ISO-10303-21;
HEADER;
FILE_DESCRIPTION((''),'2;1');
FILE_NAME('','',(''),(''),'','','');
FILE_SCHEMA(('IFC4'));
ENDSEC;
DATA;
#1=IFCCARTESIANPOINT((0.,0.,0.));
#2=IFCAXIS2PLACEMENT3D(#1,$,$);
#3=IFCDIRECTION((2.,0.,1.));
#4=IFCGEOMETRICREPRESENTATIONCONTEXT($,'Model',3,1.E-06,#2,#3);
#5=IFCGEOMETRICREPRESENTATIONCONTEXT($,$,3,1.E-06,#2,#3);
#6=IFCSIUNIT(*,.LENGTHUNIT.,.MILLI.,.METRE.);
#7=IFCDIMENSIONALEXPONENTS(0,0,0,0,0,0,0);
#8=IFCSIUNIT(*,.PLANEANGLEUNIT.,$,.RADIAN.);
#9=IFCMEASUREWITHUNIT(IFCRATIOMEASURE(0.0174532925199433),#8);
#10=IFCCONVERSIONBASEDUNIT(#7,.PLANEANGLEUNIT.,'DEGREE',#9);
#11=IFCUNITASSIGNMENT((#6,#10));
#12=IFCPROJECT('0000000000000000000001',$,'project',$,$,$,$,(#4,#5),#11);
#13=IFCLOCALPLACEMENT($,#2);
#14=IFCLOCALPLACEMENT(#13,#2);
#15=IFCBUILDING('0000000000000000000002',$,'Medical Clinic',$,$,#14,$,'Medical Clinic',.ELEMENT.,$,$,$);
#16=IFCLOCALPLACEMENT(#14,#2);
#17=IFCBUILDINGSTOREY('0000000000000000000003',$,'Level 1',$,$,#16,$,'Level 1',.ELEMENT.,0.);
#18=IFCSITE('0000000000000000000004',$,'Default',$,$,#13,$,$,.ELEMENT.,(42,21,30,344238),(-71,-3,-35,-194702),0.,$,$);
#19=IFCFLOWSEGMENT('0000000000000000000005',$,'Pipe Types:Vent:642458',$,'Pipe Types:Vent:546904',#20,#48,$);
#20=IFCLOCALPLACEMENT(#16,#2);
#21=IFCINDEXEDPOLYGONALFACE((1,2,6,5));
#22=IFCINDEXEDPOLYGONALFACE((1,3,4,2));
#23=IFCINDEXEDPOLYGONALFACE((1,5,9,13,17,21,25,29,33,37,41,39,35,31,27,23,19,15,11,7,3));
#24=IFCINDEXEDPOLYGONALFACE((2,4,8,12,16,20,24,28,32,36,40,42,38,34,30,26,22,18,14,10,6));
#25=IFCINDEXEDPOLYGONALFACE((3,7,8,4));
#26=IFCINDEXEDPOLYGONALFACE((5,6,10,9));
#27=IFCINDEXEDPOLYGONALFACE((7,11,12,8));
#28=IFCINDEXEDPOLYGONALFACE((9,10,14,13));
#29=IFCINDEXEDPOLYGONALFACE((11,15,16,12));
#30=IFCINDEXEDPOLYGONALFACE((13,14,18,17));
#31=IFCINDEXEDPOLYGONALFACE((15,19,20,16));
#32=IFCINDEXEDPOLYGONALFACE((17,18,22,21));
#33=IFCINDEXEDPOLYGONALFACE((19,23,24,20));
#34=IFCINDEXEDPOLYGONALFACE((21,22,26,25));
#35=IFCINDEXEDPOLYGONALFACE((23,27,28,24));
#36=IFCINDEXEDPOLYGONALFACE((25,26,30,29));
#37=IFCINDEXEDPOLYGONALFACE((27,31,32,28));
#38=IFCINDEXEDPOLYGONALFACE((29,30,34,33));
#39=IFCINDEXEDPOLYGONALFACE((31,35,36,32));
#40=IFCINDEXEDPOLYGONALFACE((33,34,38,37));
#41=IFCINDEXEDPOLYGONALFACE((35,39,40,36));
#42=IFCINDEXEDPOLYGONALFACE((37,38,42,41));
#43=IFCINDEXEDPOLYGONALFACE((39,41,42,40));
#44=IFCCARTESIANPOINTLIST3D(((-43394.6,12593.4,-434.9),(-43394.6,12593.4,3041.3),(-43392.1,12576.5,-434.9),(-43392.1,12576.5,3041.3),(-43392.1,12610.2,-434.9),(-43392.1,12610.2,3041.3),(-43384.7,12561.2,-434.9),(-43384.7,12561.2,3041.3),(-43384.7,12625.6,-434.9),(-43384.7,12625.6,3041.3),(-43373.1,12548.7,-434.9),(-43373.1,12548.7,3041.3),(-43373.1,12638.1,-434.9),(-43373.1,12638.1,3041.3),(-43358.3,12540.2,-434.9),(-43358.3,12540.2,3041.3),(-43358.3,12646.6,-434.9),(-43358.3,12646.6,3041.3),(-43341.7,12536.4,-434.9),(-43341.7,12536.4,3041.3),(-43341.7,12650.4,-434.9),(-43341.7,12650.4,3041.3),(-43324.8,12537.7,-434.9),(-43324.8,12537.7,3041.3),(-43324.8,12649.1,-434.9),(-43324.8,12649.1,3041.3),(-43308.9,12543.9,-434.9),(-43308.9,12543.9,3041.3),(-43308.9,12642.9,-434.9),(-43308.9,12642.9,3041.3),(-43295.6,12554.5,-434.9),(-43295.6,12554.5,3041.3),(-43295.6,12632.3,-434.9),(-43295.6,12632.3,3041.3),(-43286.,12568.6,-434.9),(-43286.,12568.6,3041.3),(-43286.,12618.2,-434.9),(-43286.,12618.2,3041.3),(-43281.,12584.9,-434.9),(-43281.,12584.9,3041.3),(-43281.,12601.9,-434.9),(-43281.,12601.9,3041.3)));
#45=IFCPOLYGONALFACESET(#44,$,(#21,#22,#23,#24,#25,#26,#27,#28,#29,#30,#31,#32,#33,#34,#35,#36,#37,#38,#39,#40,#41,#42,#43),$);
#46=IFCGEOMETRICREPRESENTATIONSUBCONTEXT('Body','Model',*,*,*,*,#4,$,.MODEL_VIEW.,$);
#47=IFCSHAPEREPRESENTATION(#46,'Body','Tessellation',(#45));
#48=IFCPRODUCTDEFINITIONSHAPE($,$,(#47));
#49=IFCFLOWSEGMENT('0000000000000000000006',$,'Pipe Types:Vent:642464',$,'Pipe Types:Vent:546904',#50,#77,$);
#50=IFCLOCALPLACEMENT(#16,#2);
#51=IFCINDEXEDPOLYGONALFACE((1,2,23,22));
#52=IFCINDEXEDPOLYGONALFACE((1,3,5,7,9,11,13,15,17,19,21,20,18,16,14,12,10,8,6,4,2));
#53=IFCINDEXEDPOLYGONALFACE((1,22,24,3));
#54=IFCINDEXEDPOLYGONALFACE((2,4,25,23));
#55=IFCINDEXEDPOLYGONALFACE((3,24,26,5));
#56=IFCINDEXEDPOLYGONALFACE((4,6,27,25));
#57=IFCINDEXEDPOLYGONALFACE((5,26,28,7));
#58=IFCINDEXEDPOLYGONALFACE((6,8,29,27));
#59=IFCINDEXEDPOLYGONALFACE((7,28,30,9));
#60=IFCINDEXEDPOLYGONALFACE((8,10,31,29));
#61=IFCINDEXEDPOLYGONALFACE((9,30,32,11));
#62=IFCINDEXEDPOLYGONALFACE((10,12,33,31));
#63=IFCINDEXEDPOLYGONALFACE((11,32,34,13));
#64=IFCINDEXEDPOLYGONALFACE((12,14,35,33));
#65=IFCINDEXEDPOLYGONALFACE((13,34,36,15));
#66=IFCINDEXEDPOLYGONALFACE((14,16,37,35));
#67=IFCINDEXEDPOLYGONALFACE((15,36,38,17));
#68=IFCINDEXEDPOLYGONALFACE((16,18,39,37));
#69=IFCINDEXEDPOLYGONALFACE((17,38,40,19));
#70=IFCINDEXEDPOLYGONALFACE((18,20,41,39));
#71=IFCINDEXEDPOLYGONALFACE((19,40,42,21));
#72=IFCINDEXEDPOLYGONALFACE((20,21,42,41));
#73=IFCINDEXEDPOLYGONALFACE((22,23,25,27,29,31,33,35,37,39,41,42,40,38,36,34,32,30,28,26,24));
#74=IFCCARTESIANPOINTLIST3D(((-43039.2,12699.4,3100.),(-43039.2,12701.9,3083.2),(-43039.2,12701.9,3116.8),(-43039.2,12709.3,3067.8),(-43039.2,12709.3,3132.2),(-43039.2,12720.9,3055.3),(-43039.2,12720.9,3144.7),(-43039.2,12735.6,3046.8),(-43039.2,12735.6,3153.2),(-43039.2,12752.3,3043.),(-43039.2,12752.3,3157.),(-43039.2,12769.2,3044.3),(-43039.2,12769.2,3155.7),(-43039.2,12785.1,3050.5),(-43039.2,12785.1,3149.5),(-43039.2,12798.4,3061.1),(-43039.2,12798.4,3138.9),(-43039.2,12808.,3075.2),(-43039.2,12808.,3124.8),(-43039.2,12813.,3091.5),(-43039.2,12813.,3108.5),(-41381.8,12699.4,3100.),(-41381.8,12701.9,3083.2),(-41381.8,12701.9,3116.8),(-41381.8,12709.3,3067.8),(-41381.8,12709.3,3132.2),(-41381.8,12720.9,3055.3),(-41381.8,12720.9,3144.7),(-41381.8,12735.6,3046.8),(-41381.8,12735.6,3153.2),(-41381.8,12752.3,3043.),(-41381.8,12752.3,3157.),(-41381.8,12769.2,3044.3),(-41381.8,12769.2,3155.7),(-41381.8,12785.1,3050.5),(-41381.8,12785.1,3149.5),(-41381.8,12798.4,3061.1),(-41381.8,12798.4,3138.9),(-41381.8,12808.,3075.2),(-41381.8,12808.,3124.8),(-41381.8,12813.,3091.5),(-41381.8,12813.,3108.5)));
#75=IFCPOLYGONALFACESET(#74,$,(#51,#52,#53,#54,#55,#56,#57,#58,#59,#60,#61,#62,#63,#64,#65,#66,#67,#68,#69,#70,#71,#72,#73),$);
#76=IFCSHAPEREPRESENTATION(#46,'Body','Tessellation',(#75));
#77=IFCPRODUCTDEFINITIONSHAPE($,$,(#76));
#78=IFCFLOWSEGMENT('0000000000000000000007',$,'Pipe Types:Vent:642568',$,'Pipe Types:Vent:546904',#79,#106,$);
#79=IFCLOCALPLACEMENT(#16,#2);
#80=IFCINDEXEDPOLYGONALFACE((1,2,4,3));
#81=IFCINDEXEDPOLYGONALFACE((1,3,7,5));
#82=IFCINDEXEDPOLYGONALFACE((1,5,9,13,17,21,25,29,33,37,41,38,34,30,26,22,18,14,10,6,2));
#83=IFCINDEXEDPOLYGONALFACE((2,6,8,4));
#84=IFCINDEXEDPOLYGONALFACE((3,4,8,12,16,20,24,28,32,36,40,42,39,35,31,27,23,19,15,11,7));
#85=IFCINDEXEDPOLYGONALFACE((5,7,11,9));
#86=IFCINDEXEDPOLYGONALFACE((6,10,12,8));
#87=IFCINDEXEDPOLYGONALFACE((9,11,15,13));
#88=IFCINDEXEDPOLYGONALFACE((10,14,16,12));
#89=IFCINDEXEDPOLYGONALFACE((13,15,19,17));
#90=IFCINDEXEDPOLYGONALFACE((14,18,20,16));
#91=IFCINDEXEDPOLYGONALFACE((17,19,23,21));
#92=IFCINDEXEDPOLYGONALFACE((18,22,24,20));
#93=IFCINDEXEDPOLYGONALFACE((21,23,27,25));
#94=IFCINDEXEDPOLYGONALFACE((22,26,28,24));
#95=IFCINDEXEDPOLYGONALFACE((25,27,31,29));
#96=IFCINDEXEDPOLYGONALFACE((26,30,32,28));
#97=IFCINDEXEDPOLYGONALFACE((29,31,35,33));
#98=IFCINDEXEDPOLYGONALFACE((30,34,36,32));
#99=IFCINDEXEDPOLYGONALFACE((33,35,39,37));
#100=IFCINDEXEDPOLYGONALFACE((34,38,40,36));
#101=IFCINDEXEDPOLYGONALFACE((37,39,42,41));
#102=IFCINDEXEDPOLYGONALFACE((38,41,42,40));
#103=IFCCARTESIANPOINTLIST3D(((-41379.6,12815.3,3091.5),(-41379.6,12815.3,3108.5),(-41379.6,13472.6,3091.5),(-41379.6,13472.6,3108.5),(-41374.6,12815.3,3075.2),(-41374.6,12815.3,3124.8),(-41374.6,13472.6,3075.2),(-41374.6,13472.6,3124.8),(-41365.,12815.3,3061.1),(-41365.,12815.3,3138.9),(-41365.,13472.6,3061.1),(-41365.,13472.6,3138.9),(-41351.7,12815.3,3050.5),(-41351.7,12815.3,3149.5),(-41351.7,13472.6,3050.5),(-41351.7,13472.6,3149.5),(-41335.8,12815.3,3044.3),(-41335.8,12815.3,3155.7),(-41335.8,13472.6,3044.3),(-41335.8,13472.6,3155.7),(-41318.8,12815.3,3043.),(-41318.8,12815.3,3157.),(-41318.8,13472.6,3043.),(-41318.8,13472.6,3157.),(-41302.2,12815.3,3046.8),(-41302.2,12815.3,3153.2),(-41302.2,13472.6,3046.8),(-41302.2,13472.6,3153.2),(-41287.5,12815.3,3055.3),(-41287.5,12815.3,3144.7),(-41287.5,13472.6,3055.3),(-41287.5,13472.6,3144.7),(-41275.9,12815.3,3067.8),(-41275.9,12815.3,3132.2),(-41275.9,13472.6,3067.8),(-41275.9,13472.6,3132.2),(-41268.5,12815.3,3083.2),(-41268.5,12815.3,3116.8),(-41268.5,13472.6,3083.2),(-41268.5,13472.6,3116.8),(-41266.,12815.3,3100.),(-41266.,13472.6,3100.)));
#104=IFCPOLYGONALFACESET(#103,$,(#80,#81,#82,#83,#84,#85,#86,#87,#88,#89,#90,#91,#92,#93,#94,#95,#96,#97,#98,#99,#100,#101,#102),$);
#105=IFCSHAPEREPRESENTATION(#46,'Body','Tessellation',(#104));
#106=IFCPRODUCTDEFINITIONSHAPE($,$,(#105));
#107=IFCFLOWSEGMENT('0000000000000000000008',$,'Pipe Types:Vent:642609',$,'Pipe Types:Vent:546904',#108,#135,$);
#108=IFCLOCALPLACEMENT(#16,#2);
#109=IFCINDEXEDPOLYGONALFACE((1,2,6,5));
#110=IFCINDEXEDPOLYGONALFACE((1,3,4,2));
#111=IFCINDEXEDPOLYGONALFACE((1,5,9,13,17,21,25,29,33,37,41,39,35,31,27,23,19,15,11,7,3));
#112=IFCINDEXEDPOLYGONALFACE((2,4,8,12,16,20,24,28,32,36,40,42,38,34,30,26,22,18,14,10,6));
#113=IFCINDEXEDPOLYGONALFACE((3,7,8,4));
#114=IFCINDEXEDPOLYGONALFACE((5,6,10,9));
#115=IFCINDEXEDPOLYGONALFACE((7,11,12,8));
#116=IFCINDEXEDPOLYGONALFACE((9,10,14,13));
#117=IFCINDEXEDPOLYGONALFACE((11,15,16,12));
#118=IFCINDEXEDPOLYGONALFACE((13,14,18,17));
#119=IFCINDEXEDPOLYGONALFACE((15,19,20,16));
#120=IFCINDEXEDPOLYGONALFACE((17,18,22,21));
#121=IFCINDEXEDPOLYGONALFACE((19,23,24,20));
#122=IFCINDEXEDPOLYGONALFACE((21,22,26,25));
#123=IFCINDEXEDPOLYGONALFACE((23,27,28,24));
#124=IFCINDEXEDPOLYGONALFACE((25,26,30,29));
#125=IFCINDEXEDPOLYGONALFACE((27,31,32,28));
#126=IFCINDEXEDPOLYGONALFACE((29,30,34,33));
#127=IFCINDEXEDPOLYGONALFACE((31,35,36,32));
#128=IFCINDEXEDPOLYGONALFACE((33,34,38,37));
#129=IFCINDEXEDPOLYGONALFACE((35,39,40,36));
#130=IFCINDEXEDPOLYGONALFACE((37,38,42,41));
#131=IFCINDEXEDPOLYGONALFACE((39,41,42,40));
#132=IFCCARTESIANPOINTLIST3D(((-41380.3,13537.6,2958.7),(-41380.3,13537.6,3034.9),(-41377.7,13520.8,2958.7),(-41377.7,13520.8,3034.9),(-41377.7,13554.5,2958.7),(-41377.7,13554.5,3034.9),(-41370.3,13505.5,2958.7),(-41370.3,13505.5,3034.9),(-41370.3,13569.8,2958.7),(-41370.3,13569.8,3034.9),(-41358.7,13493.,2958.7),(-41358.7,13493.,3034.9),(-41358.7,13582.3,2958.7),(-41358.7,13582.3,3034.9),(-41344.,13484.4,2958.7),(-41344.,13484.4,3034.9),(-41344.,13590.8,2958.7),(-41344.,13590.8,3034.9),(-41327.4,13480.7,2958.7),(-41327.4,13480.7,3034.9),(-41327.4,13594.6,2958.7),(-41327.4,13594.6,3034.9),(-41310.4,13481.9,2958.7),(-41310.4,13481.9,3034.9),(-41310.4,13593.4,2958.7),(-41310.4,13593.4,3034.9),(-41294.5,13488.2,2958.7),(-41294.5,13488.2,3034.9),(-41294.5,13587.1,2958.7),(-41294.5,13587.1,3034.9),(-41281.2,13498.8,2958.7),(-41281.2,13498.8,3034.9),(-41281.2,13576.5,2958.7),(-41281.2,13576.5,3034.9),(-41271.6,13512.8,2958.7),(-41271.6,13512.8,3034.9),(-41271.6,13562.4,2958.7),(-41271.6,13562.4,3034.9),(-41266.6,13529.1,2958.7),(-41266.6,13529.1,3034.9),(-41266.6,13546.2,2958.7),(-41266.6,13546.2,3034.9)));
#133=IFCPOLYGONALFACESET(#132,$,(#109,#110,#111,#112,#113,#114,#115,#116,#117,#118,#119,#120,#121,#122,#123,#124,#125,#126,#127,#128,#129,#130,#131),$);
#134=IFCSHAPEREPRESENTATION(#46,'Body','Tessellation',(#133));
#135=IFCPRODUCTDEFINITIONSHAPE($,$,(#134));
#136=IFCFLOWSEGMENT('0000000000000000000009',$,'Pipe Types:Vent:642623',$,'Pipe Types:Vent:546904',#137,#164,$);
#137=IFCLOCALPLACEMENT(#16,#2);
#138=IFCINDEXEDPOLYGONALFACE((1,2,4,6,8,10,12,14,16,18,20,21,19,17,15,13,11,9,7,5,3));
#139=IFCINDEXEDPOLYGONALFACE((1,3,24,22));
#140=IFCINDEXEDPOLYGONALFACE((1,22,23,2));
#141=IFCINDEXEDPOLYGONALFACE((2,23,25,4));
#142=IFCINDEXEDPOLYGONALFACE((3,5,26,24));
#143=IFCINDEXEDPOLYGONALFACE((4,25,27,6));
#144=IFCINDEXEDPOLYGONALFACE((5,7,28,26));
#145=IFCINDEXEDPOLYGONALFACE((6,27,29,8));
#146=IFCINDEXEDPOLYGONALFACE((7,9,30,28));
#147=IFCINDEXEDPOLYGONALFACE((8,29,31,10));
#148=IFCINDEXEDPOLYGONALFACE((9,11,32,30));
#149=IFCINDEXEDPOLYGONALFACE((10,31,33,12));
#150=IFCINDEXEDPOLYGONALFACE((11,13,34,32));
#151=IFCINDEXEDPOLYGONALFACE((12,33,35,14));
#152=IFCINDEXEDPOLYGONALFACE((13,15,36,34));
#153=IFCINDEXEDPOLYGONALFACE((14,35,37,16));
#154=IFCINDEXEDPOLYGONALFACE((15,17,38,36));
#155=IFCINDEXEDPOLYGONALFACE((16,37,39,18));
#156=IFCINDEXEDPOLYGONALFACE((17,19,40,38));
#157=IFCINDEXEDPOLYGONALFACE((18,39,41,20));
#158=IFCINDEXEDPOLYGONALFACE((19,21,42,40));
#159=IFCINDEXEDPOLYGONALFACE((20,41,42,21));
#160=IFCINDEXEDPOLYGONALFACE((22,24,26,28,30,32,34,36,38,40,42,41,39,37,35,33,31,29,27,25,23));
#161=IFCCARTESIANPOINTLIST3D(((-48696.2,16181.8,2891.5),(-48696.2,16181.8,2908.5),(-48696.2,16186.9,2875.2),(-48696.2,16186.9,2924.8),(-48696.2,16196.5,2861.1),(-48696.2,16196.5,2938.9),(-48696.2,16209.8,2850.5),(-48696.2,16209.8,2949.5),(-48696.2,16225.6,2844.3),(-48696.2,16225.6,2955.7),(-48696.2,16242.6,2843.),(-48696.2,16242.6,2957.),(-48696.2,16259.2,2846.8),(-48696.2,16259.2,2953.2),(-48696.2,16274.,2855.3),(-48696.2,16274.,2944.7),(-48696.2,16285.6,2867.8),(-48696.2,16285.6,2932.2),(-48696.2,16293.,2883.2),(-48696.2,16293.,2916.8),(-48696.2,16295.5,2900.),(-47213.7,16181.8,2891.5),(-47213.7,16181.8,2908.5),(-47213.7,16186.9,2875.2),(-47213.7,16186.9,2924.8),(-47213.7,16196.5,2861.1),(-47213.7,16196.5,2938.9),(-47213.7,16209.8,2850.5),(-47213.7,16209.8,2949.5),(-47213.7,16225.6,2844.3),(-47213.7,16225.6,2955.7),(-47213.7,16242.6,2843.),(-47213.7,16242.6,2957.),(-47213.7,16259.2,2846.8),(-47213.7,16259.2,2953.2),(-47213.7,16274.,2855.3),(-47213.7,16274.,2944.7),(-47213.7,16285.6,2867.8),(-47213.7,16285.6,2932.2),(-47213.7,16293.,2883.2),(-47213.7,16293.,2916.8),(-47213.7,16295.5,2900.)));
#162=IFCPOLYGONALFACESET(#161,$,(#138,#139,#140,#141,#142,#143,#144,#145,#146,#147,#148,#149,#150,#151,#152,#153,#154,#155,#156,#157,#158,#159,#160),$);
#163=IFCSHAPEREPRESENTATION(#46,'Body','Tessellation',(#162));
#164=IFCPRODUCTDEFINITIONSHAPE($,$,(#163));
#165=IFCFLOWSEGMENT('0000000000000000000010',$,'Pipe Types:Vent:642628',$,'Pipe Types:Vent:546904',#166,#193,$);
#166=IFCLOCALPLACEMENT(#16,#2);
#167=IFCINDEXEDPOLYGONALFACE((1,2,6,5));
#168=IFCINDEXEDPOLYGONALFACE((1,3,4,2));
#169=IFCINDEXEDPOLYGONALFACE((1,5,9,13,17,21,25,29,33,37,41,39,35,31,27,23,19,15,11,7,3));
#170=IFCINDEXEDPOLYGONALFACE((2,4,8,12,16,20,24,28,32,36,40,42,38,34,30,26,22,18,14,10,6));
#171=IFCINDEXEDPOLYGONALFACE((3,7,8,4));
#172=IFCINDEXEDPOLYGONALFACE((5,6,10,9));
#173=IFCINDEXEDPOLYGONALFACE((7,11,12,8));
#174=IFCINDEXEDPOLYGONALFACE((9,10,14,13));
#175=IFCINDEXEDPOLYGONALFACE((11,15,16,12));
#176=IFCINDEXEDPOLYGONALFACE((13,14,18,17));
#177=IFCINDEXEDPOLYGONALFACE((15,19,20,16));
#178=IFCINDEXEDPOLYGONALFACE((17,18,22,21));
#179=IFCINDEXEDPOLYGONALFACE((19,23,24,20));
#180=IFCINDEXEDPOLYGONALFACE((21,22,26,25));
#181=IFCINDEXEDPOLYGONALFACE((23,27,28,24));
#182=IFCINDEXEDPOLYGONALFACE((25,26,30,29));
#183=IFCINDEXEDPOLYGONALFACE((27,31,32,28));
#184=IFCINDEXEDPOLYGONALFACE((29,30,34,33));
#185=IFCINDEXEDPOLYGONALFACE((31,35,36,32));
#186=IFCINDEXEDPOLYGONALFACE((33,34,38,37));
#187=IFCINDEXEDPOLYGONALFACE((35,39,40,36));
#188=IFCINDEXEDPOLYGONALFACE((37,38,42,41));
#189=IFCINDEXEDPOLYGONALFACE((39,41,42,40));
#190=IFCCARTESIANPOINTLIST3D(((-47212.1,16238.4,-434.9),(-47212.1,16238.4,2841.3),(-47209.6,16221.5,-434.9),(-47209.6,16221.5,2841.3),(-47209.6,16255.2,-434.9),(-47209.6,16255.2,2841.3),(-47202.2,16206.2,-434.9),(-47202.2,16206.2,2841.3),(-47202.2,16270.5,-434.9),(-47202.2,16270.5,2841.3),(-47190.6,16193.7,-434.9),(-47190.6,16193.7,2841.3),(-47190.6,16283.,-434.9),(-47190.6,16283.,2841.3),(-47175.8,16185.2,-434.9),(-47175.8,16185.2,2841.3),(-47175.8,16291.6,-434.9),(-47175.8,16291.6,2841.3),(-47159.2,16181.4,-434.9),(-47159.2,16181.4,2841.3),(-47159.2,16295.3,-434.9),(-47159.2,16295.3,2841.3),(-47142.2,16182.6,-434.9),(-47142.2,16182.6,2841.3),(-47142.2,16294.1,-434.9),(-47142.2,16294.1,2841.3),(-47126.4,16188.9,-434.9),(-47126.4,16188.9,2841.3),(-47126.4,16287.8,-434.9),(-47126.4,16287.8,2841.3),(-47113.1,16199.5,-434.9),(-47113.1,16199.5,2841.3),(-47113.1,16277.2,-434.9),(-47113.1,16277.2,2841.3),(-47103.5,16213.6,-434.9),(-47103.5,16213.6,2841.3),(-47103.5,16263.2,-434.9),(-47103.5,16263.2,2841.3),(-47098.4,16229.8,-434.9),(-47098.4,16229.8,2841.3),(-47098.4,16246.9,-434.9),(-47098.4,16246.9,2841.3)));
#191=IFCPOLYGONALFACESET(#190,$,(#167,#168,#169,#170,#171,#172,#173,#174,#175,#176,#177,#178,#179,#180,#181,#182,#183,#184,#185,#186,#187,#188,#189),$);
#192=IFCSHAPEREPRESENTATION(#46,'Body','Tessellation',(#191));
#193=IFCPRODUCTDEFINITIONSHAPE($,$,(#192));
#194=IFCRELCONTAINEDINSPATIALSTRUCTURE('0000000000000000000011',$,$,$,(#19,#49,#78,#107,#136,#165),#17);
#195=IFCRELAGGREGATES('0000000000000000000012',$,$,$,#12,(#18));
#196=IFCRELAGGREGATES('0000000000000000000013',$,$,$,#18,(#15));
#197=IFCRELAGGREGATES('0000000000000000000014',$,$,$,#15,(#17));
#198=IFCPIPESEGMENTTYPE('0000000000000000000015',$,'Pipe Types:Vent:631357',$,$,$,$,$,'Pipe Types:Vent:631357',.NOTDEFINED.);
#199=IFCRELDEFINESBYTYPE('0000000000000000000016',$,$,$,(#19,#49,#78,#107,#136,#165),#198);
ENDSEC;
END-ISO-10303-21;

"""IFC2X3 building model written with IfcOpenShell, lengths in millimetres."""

from ifc_helpers import new_model, entity, si_unit, converted_unit, direction, frame, origin, origin_2d_with_axis, place, context, subcontext, project, spatial, circle, extrude, type_object, element, save


model = new_model("IFC2X3")

# Units and contexts
model_context = context("Model", 3, precision=1e-06, world=origin(), true_north=direction((2.0, 0.0, 1.0)))
context_of_model = context(None, 3, precision=1e-06, world=origin(), true_north=direction((2.0, 0.0, 1.0)))
body_context = subcontext(model_context, "Body", "Model", "MODEL_VIEW")
ifc_project = project(units=[si_unit("LENGTHUNIT", "METRE", prefix="MILLI"), converted_unit("PLANEANGLEUNIT", "DEGREE", entity("IfcRatioMeasure", 0.0174532925199433), si_unit("PLANEANGLEUNIT", "RADIAN"), dimensions=[0, 0, 0, 0, 0, 0, 0])], contexts=[model_context, context_of_model])

# Site, building, storey
site_placement = place(None, origin())
site = spatial("IfcSite", under=ifc_project, at=site_placement, Name="Default", CompositionType="ELEMENT", RefLatitude=(42, 21, 30, 344238), RefLongitude=(-71, -3, -35, -194702), RefElevation=0.0)
building_placement = place(site_placement, origin())
building = spatial("IfcBuilding", under=site, at=building_placement, Name="Medical Clinic", LongName="Medical Clinic", CompositionType="ELEMENT")
storey_placement = place(building_placement, origin())
storey = spatial("IfcBuildingStorey", under=building, at=storey_placement, Name="Level 1", LongName="Level 1", CompositionType="ELEMENT", Elevation=0.0)

# Flow segments
pipe_segment_type_1 = type_object("IfcPipeSegmentType", Name="Pipe Types:Vent:631357", ElementType="Pipe Types:Vent:631357", PredefinedType="NOTDEFINED")
flow_segment_1_placement = place(storey_placement, origin())
element("IfcFlowSegment", 1, at=flow_segment_1_placement, inside=storey, type_object=pipe_segment_type_1, Name="Pipe Types:Vent:642458", ObjectType="Pipe Types:Vent:546904", context=body_context, shape_type="SweptSolid", body=[
    extrude(circle(Radius=57.1, at=origin_2d_with_axis()), frame((-43337.5, 12593.4, -434.9), z_axis=(0.0, 0.0, 1.0), x_axis=(-1.0, 0.0, 0.0)), (0.0, 0.0, 1.0), 3476.2),
])
flow_segment_2_placement = place(storey_placement, origin())
element("IfcFlowSegment", 2, at=flow_segment_2_placement, inside=storey, type_object=pipe_segment_type_1, Name="Pipe Types:Vent:642464", ObjectType="Pipe Types:Vent:546904", context=body_context, shape_type="SweptSolid", body=[
    extrude(circle(Radius=57.1, at=origin_2d_with_axis()), frame((-43039.2, 12756.5, 3100.0), z_axis=(1.0, 0.0, 0.0), x_axis=(0.0, -1.0, 0.0)), (0.0, 0.0, 1.0), 1657.3),
])
flow_segment_3_placement = place(storey_placement, origin())
element("IfcFlowSegment", 3, at=flow_segment_3_placement, inside=storey, type_object=pipe_segment_type_1, Name="Pipe Types:Vent:642568", ObjectType="Pipe Types:Vent:546904", context=body_context, shape_type="SweptSolid", body=[
    extrude(circle(Radius=57.1, at=origin_2d_with_axis()), frame((-41323.1, 12815.3, 3100.0), z_axis=(0.0, 1.0, 0.0), x_axis=(1.0, 0.0, 0.0)), (0.0, 0.0, 1.0), 657.3),
])
flow_segment_4_placement = place(storey_placement, origin())
element("IfcFlowSegment", 4, at=flow_segment_4_placement, inside=storey, type_object=pipe_segment_type_1, Name="Pipe Types:Vent:642609", ObjectType="Pipe Types:Vent:546904", context=body_context, shape_type="SweptSolid", body=[
    extrude(circle(Radius=57.1, at=origin_2d_with_axis()), frame((-41323.1, 13537.6, 2958.7), z_axis=(0.0, 0.0, 1.0), x_axis=(-1.0, 0.0, 0.0)), (0.0, 0.0, 1.0), 76.2),
])
flow_segment_5_placement = place(storey_placement, origin())
element("IfcFlowSegment", 5, at=flow_segment_5_placement, inside=storey, type_object=pipe_segment_type_1, Name="Pipe Types:Vent:642623", ObjectType="Pipe Types:Vent:546904", context=body_context, shape_type="SweptSolid", body=[
    extrude(circle(Radius=57.1, at=origin_2d_with_axis()), frame((-48696.2, 16238.4, 2900.0), z_axis=(1.0, 0.0, 0.0), x_axis=(0.0, 1.0, 0.0)), (0.0, 0.0, 1.0), 1482.5),
])
flow_segment_6_placement = place(storey_placement, origin())
element("IfcFlowSegment", 6, at=flow_segment_6_placement, inside=storey, type_object=pipe_segment_type_1, Name="Pipe Types:Vent:642628", ObjectType="Pipe Types:Vent:546904", context=body_context, shape_type="SweptSolid", body=[
    extrude(circle(Radius=57.1, at=origin_2d_with_axis()), frame((-47155.0, 16238.4, -434.9), z_axis=(0.0, 0.0, 1.0), x_axis=(-1.0, 0.0, 0.0)), (0.0, 0.0, 1.0), 3276.2),
])

save(model, "model.ifc")
